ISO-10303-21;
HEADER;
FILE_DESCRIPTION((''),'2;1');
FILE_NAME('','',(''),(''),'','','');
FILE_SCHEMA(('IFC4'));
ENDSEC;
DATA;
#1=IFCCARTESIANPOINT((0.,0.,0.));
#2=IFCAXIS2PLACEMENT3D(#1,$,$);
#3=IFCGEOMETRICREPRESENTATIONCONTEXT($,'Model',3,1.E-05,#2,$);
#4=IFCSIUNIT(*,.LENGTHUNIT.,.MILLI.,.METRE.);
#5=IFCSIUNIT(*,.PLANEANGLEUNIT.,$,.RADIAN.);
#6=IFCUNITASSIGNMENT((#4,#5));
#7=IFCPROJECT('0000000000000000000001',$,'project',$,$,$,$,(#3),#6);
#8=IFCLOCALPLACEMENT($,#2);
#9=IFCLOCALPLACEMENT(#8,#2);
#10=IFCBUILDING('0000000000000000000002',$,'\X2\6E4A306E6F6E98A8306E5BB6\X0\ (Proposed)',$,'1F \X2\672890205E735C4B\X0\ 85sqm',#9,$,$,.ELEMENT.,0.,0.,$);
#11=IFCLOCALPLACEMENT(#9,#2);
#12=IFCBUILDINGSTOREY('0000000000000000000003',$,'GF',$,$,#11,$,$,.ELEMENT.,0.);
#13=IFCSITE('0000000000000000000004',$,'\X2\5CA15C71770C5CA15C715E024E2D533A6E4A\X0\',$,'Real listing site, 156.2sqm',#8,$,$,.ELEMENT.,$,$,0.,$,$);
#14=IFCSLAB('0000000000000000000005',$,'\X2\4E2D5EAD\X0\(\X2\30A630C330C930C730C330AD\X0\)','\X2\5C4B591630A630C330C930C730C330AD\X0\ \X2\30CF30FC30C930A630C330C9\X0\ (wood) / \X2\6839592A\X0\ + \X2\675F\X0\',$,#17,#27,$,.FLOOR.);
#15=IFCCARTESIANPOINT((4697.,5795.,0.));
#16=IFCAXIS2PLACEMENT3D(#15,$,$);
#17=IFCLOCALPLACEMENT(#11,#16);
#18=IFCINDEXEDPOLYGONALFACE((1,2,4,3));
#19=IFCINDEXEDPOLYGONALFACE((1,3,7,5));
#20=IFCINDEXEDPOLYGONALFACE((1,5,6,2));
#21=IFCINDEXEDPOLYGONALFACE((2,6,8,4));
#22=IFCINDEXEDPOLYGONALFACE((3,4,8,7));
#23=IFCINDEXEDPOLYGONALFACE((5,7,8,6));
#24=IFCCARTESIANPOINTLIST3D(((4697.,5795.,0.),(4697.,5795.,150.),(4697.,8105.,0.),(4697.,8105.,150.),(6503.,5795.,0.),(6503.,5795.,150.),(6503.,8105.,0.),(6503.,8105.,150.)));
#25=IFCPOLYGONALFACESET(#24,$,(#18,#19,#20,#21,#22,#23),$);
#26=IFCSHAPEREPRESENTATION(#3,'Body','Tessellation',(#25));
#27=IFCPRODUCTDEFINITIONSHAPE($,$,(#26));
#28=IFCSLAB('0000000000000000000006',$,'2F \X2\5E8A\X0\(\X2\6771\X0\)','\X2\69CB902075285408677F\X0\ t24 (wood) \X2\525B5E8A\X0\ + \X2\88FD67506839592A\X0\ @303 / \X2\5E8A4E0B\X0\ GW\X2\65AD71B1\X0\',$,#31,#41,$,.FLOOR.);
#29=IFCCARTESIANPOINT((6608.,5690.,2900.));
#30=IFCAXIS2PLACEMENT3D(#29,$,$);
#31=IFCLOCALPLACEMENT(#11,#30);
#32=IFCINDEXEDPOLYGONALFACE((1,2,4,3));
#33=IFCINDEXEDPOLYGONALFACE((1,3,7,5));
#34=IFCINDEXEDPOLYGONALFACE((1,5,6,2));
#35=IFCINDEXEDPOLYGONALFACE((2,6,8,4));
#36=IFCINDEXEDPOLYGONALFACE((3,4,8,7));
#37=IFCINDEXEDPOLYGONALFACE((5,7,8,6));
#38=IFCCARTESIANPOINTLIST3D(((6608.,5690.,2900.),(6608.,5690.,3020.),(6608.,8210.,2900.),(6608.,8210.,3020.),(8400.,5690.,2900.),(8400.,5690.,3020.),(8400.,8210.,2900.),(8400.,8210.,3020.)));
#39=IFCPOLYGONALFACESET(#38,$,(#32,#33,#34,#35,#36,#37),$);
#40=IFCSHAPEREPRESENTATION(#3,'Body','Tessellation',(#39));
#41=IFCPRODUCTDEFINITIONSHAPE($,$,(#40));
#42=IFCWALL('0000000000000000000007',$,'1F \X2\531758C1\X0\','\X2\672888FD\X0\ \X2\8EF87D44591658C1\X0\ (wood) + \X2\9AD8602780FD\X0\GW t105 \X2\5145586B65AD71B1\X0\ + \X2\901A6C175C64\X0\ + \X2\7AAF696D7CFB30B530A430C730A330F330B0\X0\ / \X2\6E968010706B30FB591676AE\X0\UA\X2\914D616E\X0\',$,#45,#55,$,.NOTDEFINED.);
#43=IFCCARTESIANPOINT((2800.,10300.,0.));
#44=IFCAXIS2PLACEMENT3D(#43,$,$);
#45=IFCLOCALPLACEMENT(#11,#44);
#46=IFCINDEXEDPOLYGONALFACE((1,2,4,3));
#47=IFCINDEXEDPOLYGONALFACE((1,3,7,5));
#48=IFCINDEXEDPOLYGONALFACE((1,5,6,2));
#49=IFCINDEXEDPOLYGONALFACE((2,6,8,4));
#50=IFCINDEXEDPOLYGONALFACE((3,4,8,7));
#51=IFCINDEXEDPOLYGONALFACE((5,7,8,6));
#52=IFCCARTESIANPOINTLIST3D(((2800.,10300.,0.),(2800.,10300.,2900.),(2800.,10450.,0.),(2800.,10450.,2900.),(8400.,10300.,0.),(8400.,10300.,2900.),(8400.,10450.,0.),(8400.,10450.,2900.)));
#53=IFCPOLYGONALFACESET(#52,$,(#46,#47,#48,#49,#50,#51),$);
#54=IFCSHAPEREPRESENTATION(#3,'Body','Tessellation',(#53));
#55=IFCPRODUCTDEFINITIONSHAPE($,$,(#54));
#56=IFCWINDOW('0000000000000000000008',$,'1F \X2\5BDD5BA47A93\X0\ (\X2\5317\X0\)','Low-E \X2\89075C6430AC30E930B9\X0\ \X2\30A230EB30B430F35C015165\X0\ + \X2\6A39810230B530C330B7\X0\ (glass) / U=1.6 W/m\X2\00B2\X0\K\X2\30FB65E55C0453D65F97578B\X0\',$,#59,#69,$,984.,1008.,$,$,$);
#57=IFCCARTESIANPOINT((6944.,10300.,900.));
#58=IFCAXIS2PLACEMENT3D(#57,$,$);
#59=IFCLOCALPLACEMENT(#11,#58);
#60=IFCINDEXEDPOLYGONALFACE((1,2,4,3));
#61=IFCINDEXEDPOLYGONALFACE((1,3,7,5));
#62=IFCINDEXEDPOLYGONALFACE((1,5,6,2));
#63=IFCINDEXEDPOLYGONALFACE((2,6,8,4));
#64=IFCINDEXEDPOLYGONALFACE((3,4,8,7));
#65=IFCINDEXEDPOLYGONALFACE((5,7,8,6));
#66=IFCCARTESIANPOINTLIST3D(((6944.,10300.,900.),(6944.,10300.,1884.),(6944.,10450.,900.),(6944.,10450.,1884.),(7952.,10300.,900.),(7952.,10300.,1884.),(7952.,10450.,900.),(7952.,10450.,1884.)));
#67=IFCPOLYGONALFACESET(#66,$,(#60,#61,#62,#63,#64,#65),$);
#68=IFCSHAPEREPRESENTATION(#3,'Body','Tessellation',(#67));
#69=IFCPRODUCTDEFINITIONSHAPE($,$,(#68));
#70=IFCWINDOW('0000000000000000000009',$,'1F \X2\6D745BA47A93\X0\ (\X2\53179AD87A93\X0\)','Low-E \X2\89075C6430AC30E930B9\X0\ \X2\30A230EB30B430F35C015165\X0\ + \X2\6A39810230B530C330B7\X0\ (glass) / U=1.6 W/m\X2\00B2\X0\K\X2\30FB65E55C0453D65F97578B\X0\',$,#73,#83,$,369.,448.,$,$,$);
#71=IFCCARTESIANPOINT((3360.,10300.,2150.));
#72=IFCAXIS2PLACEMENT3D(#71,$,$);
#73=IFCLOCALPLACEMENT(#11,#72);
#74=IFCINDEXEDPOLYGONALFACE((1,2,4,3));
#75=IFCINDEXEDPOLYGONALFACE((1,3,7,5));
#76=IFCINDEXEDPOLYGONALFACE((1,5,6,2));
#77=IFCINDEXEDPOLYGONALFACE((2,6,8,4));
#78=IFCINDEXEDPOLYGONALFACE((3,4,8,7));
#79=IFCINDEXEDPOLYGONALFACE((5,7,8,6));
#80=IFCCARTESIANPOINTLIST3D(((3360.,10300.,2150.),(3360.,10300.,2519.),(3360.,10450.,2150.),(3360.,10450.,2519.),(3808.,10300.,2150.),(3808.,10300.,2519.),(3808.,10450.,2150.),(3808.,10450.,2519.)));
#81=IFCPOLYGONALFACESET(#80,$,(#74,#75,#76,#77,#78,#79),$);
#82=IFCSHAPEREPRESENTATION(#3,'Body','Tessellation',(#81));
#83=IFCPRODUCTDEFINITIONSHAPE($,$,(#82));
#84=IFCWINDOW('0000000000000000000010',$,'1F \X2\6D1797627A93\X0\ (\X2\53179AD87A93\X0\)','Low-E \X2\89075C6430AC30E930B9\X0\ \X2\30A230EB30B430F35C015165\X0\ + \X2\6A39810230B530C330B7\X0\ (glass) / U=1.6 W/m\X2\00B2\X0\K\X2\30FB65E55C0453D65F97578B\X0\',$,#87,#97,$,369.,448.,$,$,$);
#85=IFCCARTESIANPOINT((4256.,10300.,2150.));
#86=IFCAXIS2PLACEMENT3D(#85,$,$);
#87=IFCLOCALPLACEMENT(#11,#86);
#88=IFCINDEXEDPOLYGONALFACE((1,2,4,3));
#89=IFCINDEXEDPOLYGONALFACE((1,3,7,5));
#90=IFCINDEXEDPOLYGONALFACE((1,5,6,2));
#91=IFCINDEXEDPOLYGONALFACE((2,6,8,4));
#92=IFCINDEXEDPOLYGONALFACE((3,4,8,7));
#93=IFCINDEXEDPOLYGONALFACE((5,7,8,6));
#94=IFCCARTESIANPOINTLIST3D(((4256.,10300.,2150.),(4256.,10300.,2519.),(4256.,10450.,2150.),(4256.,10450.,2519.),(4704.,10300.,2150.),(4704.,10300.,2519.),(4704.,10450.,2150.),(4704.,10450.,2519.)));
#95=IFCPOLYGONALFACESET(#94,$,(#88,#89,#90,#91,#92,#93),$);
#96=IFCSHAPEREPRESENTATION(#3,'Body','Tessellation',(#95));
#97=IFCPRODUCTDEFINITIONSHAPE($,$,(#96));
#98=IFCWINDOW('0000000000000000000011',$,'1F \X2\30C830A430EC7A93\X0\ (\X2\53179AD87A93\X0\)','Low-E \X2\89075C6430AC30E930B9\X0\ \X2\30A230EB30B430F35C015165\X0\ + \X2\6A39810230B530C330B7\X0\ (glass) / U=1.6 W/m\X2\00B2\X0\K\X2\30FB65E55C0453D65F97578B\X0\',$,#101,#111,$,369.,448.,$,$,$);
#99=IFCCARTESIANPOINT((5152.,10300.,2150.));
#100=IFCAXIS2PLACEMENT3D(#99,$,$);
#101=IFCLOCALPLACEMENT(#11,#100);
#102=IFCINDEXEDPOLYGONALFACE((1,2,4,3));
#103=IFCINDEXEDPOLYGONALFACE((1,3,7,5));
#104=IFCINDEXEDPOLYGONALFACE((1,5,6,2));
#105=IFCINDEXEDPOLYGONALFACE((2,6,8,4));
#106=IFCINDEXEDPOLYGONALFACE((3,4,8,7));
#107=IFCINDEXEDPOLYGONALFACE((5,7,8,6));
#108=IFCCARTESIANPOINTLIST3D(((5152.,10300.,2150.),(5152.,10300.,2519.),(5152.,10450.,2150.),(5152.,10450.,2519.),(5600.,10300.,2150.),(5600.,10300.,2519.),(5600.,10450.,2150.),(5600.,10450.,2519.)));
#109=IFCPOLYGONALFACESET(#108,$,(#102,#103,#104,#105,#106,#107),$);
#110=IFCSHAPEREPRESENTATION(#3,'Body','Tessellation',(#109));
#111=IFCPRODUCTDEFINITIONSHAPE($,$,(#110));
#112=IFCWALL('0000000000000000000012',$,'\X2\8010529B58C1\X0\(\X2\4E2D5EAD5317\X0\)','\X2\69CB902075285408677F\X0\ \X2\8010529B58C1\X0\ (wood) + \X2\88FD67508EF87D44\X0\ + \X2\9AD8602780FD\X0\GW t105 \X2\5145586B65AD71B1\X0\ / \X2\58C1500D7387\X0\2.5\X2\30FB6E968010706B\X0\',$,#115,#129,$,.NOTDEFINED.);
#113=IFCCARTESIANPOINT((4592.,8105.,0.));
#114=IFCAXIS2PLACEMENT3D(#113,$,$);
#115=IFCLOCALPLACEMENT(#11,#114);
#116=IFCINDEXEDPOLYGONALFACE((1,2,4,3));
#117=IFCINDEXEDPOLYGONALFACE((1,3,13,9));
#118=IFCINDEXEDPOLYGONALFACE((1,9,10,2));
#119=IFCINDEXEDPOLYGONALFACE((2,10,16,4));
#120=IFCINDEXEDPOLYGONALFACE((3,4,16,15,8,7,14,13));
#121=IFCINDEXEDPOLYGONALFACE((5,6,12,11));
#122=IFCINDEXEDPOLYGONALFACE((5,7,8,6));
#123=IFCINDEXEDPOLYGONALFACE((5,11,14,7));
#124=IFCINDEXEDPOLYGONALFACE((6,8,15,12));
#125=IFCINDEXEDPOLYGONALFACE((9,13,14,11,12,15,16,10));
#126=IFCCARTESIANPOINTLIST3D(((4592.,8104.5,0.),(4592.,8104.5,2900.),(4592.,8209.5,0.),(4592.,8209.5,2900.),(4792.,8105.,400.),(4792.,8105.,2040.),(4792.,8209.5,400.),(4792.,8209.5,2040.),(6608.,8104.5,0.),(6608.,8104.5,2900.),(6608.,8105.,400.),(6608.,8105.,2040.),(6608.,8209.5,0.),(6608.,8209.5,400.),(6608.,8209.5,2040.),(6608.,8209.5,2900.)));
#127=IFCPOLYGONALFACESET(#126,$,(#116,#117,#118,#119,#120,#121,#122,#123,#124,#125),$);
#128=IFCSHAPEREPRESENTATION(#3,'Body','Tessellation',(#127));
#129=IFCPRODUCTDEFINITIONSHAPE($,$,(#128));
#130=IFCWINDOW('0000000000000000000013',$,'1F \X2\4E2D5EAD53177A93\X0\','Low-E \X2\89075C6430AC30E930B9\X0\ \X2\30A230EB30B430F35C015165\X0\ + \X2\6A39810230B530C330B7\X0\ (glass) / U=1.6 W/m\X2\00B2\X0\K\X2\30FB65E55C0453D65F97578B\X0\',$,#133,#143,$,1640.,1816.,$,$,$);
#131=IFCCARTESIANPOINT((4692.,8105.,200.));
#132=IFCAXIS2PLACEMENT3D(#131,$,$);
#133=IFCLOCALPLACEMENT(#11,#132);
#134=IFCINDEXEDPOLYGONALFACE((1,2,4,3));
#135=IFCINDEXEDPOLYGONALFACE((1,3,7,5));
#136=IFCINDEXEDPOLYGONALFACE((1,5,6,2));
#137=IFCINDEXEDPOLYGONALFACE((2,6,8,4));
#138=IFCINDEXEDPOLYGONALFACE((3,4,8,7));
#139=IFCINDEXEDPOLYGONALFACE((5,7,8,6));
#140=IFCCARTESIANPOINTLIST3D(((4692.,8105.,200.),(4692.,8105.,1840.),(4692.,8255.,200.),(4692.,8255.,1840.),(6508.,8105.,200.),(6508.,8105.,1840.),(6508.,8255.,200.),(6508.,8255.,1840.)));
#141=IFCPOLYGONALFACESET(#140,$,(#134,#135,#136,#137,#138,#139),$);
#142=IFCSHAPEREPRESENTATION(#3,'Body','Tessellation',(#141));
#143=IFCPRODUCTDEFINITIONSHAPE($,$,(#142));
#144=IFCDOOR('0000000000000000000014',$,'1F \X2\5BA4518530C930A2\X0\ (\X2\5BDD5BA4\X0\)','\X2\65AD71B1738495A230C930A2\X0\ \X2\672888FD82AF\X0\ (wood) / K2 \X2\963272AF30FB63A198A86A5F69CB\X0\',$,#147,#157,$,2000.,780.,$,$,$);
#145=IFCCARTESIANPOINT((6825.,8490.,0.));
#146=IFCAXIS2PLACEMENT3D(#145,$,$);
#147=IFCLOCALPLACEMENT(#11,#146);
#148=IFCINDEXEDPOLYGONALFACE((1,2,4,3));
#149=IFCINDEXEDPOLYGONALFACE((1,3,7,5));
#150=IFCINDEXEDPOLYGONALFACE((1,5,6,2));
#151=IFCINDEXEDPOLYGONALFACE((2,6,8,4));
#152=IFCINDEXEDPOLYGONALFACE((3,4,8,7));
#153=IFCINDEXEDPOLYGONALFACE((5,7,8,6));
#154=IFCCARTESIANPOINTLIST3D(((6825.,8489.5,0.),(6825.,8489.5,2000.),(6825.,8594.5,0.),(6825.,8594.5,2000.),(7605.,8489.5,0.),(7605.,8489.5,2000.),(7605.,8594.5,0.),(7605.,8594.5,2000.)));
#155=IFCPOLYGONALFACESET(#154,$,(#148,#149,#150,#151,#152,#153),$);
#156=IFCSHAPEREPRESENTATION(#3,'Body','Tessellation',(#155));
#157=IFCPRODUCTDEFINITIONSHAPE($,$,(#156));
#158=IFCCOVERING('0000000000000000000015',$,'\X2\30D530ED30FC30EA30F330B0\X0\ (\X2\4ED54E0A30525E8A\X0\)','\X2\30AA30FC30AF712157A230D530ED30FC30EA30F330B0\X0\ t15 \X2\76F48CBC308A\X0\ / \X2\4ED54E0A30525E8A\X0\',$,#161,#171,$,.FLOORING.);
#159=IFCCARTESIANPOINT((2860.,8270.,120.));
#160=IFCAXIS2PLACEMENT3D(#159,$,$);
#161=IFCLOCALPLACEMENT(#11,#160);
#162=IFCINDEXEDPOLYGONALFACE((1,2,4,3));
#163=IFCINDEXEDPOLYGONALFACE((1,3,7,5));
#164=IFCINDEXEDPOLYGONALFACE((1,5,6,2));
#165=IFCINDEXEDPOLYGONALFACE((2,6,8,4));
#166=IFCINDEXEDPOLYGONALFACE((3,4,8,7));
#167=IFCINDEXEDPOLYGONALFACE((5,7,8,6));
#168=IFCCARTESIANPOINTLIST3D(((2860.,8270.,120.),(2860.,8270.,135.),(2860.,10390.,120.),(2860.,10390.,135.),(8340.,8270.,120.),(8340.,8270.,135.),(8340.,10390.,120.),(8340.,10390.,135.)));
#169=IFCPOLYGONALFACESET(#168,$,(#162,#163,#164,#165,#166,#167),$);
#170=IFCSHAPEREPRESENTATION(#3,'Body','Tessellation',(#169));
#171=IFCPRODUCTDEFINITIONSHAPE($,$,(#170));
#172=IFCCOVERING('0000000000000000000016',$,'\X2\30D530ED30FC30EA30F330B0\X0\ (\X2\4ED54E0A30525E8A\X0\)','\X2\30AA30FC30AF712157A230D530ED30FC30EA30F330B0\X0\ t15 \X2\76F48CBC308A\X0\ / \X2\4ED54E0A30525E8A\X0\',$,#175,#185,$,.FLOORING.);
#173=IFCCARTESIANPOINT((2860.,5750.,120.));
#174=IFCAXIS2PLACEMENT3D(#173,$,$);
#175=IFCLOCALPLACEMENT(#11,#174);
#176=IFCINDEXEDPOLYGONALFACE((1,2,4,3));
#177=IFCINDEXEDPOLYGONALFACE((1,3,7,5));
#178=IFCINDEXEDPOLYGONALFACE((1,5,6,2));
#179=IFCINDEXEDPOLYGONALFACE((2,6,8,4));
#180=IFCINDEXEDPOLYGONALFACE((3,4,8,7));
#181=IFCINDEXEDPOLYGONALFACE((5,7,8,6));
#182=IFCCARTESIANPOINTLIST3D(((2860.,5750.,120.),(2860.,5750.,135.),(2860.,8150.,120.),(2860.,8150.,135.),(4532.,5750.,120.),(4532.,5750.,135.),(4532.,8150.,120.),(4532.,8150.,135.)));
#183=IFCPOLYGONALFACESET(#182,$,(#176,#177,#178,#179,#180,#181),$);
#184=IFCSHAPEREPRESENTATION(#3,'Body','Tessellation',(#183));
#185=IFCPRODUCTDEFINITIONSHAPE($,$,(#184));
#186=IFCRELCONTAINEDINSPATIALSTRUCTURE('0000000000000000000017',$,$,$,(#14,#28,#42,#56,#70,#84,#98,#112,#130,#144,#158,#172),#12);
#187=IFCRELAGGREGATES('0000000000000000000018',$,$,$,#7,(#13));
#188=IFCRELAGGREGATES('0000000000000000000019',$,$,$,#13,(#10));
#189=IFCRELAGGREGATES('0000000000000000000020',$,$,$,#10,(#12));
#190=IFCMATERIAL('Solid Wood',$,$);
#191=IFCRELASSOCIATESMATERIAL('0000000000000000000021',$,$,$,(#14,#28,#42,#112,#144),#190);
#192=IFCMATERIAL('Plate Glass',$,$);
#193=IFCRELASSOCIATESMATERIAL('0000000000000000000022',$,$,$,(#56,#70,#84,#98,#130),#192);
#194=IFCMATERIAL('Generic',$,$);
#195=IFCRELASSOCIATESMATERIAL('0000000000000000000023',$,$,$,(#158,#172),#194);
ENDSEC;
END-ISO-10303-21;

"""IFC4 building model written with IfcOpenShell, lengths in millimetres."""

from ifc_helpers import new_model, si_unit, frame, frame_2d, origin, place, context, project, spatial, rectangle, extrude, material, element, fill, save


model = new_model("IFC4")

# Units and contexts
model_context = context("Model", 3, precision=1e-05, world=origin())
ifc_project = project(units=[si_unit("LENGTHUNIT", "METRE", prefix="MILLI"), si_unit("PLANEANGLEUNIT", "RADIAN")], contexts=[model_context])

# Site, building, storey
site_placement = place(None, origin())
site = spatial("IfcSite", under=ifc_project, at=site_placement, Name="岡山県岡山市中区湊", ObjectType="Real listing site, 156.2sqm", CompositionType="ELEMENT", RefElevation=0.0)
building_placement = place(site_placement, origin())
building = spatial("IfcBuilding", under=site, at=building_placement, Name="湊の潮風の家 (Proposed)", ObjectType="1F 木造平屋 85sqm", CompositionType="ELEMENT", ElevationOfRefHeight=0.0, ElevationOfTerrain=0.0)
storey_placement = place(building_placement, origin())
storey = spatial("IfcBuildingStorey", under=building, at=storey_placement, Name="GF", CompositionType="ELEMENT", Elevation=0.0)

# Slabs
ifc_material_1 = material(Name="Solid Wood")
slab_1_placement = place(storey_placement, frame((4697.0, 5795.0, 0.0)))
element("IfcSlab", 1, at=slab_1_placement, inside=storey, material=ifc_material_1, Name="中庭(ウッドデッキ)", Description="屋外ウッドデッキ ハードウッド (wood) / 根太 + 束", PredefinedType="FLOOR", context=model_context, shape_type="SweptSolid", body=[
    extrude(rectangle(XDim=1806.0, YDim=2310.0, at=frame_2d((903.0, 1155.0))), frame((4697.0, 5795.0, 0.0)), (0.0, 0.0, 1.0), 150.0),
])
slab_2_placement = place(storey_placement, frame((6608.0, 5690.0, 2900.0)))
element("IfcSlab", 2, at=slab_2_placement, inside=storey, material=ifc_material_1, Name="2F 床(東)", Description="構造用合板 t24 (wood) 剛床 + 製材根太 @303 / 床下 GW断熱", PredefinedType="FLOOR", context=model_context, shape_type="SweptSolid", body=[
    extrude(rectangle(XDim=1792.0, YDim=2520.0, at=frame_2d((896.0, 1260.0))), frame((6608.0, 5690.0, 2900.0)), (0.0, 0.0, 1.0), 120.0),
])

# Wall, openings, windows
wall_1_placement = place(storey_placement, frame((2800.0, 10300.0, 0.0)))
wall_1 = element("IfcWall", 3, at=wall_1_placement, inside=storey, material=ifc_material_1, Name="1F 北壁", Description="木製 軸組外壁 (wood) + 高性能GW t105 充填断熱 + 通気層 + 窯業系サイディング / 準耐火・外皮UA配慮", PredefinedType="NOTDEFINED", context=model_context, shape_type="SweptSolid", body=[
    extrude(rectangle(XDim=5600.0, YDim=150.0, at=frame_2d((2800.0, 75.0))), frame((2800.0, 10300.0, 0.0)), (0.0, 0.0, 1.0), 2900.0),
])
opening_1_placement = place(storey_placement, frame((6944.0, 10300.0, 900.0)))
opening_1 = element("IfcOpeningElement", 4, at=opening_1_placement, cuts=wall_1, PredefinedType="NOTDEFINED", context=model_context, shape_type="SweptSolid", body=[
    extrude(rectangle(XDim=1008.0, YDim=150.0, at=frame_2d((504.0, 75.0))), frame((6944.0, 10300.0, 900.0)), (0.0, 0.0, 1.0), 984.0),
])
opening_2_placement = place(storey_placement, frame((3360.0, 10300.0, 2150.0)))
opening_2 = element("IfcOpeningElement", 5, at=opening_2_placement, cuts=wall_1, PredefinedType="NOTDEFINED", context=model_context, shape_type="SweptSolid", body=[
    extrude(rectangle(XDim=448.0, YDim=150.0, at=frame_2d((224.0, 75.0))), frame((3360.0, 10300.0, 2150.0)), (0.0, 0.0, 1.0), 369.0),
])
opening_3_placement = place(storey_placement, frame((4256.0, 10300.0, 2150.0)))
opening_3 = element("IfcOpeningElement", 6, at=opening_3_placement, cuts=wall_1, PredefinedType="NOTDEFINED", context=model_context, shape_type="SweptSolid", body=[
    extrude(rectangle(XDim=448.0, YDim=150.0, at=frame_2d((224.0, 75.0))), frame((4256.0, 10300.0, 2150.0)), (0.0, 0.0, 1.0), 369.0),
])
opening_4_placement = place(storey_placement, frame((5152.0, 10300.0, 2150.0)))
opening_4 = element("IfcOpeningElement", 7, at=opening_4_placement, cuts=wall_1, PredefinedType="NOTDEFINED", context=model_context, shape_type="SweptSolid", body=[
    extrude(rectangle(XDim=448.0, YDim=150.0, at=frame_2d((224.0, 75.0))), frame((5152.0, 10300.0, 2150.0)), (0.0, 0.0, 1.0), 369.0),
])
ifc_material_2 = material(Name="Plate Glass")
window_1_placement = place(storey_placement, frame((6944.0, 10300.0, 900.0)))
window_1 = element("IfcWindow", 8, at=window_1_placement, inside=storey, material=ifc_material_2, Name="1F 寝室窓 (北)", Description="Low-E 複層ガラス アルゴン封入 + 樹脂サッシ (glass) / U=1.6 W/m²K・日射取得型", OverallHeight=984.0, OverallWidth=1008.0, context=model_context, shape_type="SweptSolid", body=[
    extrude(rectangle(XDim=1008.0, YDim=150.0, at=frame_2d((504.0, 75.0))), frame((6944.0, 10300.0, 900.0)), (0.0, 0.0, 1.0), 984.0),
])
fill(opening_1, window_1)
window_2_placement = place(storey_placement, frame((3360.0, 10300.0, 2150.0)))
window_2 = element("IfcWindow", 9, at=window_2_placement, inside=storey, material=ifc_material_2, Name="1F 浴室窓 (北高窓)", Description="Low-E 複層ガラス アルゴン封入 + 樹脂サッシ (glass) / U=1.6 W/m²K・日射取得型", OverallHeight=369.0, OverallWidth=448.0, context=model_context, shape_type="SweptSolid", body=[
    extrude(rectangle(XDim=448.0, YDim=150.0, at=frame_2d((224.0, 75.0))), frame((3360.0, 10300.0, 2150.0)), (0.0, 0.0, 1.0), 369.0),
])
fill(opening_2, window_2)
window_3_placement = place(storey_placement, frame((4256.0, 10300.0, 2150.0)))
window_3 = element("IfcWindow", 10, at=window_3_placement, inside=storey, material=ifc_material_2, Name="1F 洗面窓 (北高窓)", Description="Low-E 複層ガラス アルゴン封入 + 樹脂サッシ (glass) / U=1.6 W/m²K・日射取得型", OverallHeight=369.0, OverallWidth=448.0, context=model_context, shape_type="SweptSolid", body=[
    extrude(rectangle(XDim=448.0, YDim=150.0, at=frame_2d((224.0, 75.0))), frame((4256.0, 10300.0, 2150.0)), (0.0, 0.0, 1.0), 369.0),
])
fill(opening_3, window_3)
window_4_placement = place(storey_placement, frame((5152.0, 10300.0, 2150.0)))
window_4 = element("IfcWindow", 11, at=window_4_placement, inside=storey, material=ifc_material_2, Name="1F トイレ窓 (北高窓)", Description="Low-E 複層ガラス アルゴン封入 + 樹脂サッシ (glass) / U=1.6 W/m²K・日射取得型", OverallHeight=369.0, OverallWidth=448.0, context=model_context, shape_type="SweptSolid", body=[
    extrude(rectangle(XDim=448.0, YDim=150.0, at=frame_2d((224.0, 75.0))), frame((5152.0, 10300.0, 2150.0)), (0.0, 0.0, 1.0), 369.0),
])
fill(opening_4, window_4)

# Wall, opening, window
wall_2_placement = place(storey_placement, frame((4592.0, 8105.0, 0.0)))
wall_2 = element("IfcWall", 12, at=wall_2_placement, inside=storey, material=ifc_material_1, Name="耐力壁(中庭北)", Description="構造用合板 耐力壁 (wood) + 製材軸組 + 高性能GW t105 充填断熱 / 壁倍率2.5・準耐火", PredefinedType="NOTDEFINED", context=model_context, shape_type="SweptSolid", body=[
    extrude(rectangle(XDim=2016.0, YDim=105.0, at=frame_2d((1008.0, 52.0))), frame((4592.0, 8105.0, 0.0)), (0.0, 0.0, 1.0), 2900.0),
])
opening_5_placement = place(storey_placement, frame((4692.0, 8105.0, 200.0)))
opening_5 = element("IfcOpeningElement", 13, at=opening_5_placement, cuts=wall_2, PredefinedType="NOTDEFINED", context=model_context, shape_type="SweptSolid", body=[
    extrude(rectangle(XDim=1816.0, YDim=150.0, at=frame_2d((908.0, 75.0))), frame((4692.0, 8105.0, 200.0)), (0.0, 0.0, 1.0), 1640.0),
])
window_5_placement = place(storey_placement, frame((4692.0, 8105.0, 200.0)))
window_5 = element("IfcWindow", 14, at=window_5_placement, inside=storey, material=ifc_material_2, Name="1F 中庭北窓", Description="Low-E 複層ガラス アルゴン封入 + 樹脂サッシ (glass) / U=1.6 W/m²K・日射取得型", OverallHeight=1640.0, OverallWidth=1816.0, context=model_context, shape_type="SweptSolid", body=[
    extrude(rectangle(XDim=1816.0, YDim=150.0, at=frame_2d((908.0, 75.0))), frame((4692.0, 8105.0, 200.0)), (0.0, 0.0, 1.0), 1640.0),
])
fill(opening_5, window_5)

# Door
door_1_placement = place(storey_placement, frame((6825.0, 8490.0, 0.0)))
element("IfcDoor", 15, at=door_1_placement, inside=storey, material=ifc_material_1, Name="1F 室内ドア (寝室)", Description="断熱玄関ドア 木製芯 (wood) / K2 防犯・採風機構", OverallHeight=2000.0, OverallWidth=780.0, context=model_context, shape_type="SweptSolid", body=[
    extrude(rectangle(XDim=780.0, YDim=105.0, at=frame_2d((390.0, 52.0))), frame((6825.0, 8490.0, 0.0)), (0.0, 0.0, 1.0), 2000.0),
])

# Coverings
ifc_material_3 = material(Name="Generic")
covering_1_placement = place(storey_placement, frame((2860.0, 8270.0, 120.0)))
element("IfcCovering", 16, at=covering_1_placement, inside=storey, material=ifc_material_3, Name="フローリング (仕上げ床)", Description="オーク無垢フローリング t15 直貼り / 仕上げ床", PredefinedType="FLOORING", context=model_context, shape_type="SweptSolid", body=[
    extrude(rectangle(XDim=5480.0, YDim=2120.0, at=frame_2d((2740.0, 1060.0))), frame((2860.0, 8270.0, 120.0)), (0.0, 0.0, 1.0), 15.0),
])
covering_2_placement = place(storey_placement, frame((2860.0, 5750.0, 120.0)))
element("IfcCovering", 17, at=covering_2_placement, inside=storey, material=ifc_material_3, Name="フローリング (仕上げ床)", Description="オーク無垢フローリング t15 直貼り / 仕上げ床", PredefinedType="FLOORING", context=model_context, shape_type="SweptSolid", body=[
    extrude(rectangle(XDim=1672.0, YDim=2400.0, at=frame_2d((836.0, 1200.0))), frame((2860.0, 5750.0, 120.0)), (0.0, 0.0, 1.0), 15.0),
])

save(model, "model.ifc")
